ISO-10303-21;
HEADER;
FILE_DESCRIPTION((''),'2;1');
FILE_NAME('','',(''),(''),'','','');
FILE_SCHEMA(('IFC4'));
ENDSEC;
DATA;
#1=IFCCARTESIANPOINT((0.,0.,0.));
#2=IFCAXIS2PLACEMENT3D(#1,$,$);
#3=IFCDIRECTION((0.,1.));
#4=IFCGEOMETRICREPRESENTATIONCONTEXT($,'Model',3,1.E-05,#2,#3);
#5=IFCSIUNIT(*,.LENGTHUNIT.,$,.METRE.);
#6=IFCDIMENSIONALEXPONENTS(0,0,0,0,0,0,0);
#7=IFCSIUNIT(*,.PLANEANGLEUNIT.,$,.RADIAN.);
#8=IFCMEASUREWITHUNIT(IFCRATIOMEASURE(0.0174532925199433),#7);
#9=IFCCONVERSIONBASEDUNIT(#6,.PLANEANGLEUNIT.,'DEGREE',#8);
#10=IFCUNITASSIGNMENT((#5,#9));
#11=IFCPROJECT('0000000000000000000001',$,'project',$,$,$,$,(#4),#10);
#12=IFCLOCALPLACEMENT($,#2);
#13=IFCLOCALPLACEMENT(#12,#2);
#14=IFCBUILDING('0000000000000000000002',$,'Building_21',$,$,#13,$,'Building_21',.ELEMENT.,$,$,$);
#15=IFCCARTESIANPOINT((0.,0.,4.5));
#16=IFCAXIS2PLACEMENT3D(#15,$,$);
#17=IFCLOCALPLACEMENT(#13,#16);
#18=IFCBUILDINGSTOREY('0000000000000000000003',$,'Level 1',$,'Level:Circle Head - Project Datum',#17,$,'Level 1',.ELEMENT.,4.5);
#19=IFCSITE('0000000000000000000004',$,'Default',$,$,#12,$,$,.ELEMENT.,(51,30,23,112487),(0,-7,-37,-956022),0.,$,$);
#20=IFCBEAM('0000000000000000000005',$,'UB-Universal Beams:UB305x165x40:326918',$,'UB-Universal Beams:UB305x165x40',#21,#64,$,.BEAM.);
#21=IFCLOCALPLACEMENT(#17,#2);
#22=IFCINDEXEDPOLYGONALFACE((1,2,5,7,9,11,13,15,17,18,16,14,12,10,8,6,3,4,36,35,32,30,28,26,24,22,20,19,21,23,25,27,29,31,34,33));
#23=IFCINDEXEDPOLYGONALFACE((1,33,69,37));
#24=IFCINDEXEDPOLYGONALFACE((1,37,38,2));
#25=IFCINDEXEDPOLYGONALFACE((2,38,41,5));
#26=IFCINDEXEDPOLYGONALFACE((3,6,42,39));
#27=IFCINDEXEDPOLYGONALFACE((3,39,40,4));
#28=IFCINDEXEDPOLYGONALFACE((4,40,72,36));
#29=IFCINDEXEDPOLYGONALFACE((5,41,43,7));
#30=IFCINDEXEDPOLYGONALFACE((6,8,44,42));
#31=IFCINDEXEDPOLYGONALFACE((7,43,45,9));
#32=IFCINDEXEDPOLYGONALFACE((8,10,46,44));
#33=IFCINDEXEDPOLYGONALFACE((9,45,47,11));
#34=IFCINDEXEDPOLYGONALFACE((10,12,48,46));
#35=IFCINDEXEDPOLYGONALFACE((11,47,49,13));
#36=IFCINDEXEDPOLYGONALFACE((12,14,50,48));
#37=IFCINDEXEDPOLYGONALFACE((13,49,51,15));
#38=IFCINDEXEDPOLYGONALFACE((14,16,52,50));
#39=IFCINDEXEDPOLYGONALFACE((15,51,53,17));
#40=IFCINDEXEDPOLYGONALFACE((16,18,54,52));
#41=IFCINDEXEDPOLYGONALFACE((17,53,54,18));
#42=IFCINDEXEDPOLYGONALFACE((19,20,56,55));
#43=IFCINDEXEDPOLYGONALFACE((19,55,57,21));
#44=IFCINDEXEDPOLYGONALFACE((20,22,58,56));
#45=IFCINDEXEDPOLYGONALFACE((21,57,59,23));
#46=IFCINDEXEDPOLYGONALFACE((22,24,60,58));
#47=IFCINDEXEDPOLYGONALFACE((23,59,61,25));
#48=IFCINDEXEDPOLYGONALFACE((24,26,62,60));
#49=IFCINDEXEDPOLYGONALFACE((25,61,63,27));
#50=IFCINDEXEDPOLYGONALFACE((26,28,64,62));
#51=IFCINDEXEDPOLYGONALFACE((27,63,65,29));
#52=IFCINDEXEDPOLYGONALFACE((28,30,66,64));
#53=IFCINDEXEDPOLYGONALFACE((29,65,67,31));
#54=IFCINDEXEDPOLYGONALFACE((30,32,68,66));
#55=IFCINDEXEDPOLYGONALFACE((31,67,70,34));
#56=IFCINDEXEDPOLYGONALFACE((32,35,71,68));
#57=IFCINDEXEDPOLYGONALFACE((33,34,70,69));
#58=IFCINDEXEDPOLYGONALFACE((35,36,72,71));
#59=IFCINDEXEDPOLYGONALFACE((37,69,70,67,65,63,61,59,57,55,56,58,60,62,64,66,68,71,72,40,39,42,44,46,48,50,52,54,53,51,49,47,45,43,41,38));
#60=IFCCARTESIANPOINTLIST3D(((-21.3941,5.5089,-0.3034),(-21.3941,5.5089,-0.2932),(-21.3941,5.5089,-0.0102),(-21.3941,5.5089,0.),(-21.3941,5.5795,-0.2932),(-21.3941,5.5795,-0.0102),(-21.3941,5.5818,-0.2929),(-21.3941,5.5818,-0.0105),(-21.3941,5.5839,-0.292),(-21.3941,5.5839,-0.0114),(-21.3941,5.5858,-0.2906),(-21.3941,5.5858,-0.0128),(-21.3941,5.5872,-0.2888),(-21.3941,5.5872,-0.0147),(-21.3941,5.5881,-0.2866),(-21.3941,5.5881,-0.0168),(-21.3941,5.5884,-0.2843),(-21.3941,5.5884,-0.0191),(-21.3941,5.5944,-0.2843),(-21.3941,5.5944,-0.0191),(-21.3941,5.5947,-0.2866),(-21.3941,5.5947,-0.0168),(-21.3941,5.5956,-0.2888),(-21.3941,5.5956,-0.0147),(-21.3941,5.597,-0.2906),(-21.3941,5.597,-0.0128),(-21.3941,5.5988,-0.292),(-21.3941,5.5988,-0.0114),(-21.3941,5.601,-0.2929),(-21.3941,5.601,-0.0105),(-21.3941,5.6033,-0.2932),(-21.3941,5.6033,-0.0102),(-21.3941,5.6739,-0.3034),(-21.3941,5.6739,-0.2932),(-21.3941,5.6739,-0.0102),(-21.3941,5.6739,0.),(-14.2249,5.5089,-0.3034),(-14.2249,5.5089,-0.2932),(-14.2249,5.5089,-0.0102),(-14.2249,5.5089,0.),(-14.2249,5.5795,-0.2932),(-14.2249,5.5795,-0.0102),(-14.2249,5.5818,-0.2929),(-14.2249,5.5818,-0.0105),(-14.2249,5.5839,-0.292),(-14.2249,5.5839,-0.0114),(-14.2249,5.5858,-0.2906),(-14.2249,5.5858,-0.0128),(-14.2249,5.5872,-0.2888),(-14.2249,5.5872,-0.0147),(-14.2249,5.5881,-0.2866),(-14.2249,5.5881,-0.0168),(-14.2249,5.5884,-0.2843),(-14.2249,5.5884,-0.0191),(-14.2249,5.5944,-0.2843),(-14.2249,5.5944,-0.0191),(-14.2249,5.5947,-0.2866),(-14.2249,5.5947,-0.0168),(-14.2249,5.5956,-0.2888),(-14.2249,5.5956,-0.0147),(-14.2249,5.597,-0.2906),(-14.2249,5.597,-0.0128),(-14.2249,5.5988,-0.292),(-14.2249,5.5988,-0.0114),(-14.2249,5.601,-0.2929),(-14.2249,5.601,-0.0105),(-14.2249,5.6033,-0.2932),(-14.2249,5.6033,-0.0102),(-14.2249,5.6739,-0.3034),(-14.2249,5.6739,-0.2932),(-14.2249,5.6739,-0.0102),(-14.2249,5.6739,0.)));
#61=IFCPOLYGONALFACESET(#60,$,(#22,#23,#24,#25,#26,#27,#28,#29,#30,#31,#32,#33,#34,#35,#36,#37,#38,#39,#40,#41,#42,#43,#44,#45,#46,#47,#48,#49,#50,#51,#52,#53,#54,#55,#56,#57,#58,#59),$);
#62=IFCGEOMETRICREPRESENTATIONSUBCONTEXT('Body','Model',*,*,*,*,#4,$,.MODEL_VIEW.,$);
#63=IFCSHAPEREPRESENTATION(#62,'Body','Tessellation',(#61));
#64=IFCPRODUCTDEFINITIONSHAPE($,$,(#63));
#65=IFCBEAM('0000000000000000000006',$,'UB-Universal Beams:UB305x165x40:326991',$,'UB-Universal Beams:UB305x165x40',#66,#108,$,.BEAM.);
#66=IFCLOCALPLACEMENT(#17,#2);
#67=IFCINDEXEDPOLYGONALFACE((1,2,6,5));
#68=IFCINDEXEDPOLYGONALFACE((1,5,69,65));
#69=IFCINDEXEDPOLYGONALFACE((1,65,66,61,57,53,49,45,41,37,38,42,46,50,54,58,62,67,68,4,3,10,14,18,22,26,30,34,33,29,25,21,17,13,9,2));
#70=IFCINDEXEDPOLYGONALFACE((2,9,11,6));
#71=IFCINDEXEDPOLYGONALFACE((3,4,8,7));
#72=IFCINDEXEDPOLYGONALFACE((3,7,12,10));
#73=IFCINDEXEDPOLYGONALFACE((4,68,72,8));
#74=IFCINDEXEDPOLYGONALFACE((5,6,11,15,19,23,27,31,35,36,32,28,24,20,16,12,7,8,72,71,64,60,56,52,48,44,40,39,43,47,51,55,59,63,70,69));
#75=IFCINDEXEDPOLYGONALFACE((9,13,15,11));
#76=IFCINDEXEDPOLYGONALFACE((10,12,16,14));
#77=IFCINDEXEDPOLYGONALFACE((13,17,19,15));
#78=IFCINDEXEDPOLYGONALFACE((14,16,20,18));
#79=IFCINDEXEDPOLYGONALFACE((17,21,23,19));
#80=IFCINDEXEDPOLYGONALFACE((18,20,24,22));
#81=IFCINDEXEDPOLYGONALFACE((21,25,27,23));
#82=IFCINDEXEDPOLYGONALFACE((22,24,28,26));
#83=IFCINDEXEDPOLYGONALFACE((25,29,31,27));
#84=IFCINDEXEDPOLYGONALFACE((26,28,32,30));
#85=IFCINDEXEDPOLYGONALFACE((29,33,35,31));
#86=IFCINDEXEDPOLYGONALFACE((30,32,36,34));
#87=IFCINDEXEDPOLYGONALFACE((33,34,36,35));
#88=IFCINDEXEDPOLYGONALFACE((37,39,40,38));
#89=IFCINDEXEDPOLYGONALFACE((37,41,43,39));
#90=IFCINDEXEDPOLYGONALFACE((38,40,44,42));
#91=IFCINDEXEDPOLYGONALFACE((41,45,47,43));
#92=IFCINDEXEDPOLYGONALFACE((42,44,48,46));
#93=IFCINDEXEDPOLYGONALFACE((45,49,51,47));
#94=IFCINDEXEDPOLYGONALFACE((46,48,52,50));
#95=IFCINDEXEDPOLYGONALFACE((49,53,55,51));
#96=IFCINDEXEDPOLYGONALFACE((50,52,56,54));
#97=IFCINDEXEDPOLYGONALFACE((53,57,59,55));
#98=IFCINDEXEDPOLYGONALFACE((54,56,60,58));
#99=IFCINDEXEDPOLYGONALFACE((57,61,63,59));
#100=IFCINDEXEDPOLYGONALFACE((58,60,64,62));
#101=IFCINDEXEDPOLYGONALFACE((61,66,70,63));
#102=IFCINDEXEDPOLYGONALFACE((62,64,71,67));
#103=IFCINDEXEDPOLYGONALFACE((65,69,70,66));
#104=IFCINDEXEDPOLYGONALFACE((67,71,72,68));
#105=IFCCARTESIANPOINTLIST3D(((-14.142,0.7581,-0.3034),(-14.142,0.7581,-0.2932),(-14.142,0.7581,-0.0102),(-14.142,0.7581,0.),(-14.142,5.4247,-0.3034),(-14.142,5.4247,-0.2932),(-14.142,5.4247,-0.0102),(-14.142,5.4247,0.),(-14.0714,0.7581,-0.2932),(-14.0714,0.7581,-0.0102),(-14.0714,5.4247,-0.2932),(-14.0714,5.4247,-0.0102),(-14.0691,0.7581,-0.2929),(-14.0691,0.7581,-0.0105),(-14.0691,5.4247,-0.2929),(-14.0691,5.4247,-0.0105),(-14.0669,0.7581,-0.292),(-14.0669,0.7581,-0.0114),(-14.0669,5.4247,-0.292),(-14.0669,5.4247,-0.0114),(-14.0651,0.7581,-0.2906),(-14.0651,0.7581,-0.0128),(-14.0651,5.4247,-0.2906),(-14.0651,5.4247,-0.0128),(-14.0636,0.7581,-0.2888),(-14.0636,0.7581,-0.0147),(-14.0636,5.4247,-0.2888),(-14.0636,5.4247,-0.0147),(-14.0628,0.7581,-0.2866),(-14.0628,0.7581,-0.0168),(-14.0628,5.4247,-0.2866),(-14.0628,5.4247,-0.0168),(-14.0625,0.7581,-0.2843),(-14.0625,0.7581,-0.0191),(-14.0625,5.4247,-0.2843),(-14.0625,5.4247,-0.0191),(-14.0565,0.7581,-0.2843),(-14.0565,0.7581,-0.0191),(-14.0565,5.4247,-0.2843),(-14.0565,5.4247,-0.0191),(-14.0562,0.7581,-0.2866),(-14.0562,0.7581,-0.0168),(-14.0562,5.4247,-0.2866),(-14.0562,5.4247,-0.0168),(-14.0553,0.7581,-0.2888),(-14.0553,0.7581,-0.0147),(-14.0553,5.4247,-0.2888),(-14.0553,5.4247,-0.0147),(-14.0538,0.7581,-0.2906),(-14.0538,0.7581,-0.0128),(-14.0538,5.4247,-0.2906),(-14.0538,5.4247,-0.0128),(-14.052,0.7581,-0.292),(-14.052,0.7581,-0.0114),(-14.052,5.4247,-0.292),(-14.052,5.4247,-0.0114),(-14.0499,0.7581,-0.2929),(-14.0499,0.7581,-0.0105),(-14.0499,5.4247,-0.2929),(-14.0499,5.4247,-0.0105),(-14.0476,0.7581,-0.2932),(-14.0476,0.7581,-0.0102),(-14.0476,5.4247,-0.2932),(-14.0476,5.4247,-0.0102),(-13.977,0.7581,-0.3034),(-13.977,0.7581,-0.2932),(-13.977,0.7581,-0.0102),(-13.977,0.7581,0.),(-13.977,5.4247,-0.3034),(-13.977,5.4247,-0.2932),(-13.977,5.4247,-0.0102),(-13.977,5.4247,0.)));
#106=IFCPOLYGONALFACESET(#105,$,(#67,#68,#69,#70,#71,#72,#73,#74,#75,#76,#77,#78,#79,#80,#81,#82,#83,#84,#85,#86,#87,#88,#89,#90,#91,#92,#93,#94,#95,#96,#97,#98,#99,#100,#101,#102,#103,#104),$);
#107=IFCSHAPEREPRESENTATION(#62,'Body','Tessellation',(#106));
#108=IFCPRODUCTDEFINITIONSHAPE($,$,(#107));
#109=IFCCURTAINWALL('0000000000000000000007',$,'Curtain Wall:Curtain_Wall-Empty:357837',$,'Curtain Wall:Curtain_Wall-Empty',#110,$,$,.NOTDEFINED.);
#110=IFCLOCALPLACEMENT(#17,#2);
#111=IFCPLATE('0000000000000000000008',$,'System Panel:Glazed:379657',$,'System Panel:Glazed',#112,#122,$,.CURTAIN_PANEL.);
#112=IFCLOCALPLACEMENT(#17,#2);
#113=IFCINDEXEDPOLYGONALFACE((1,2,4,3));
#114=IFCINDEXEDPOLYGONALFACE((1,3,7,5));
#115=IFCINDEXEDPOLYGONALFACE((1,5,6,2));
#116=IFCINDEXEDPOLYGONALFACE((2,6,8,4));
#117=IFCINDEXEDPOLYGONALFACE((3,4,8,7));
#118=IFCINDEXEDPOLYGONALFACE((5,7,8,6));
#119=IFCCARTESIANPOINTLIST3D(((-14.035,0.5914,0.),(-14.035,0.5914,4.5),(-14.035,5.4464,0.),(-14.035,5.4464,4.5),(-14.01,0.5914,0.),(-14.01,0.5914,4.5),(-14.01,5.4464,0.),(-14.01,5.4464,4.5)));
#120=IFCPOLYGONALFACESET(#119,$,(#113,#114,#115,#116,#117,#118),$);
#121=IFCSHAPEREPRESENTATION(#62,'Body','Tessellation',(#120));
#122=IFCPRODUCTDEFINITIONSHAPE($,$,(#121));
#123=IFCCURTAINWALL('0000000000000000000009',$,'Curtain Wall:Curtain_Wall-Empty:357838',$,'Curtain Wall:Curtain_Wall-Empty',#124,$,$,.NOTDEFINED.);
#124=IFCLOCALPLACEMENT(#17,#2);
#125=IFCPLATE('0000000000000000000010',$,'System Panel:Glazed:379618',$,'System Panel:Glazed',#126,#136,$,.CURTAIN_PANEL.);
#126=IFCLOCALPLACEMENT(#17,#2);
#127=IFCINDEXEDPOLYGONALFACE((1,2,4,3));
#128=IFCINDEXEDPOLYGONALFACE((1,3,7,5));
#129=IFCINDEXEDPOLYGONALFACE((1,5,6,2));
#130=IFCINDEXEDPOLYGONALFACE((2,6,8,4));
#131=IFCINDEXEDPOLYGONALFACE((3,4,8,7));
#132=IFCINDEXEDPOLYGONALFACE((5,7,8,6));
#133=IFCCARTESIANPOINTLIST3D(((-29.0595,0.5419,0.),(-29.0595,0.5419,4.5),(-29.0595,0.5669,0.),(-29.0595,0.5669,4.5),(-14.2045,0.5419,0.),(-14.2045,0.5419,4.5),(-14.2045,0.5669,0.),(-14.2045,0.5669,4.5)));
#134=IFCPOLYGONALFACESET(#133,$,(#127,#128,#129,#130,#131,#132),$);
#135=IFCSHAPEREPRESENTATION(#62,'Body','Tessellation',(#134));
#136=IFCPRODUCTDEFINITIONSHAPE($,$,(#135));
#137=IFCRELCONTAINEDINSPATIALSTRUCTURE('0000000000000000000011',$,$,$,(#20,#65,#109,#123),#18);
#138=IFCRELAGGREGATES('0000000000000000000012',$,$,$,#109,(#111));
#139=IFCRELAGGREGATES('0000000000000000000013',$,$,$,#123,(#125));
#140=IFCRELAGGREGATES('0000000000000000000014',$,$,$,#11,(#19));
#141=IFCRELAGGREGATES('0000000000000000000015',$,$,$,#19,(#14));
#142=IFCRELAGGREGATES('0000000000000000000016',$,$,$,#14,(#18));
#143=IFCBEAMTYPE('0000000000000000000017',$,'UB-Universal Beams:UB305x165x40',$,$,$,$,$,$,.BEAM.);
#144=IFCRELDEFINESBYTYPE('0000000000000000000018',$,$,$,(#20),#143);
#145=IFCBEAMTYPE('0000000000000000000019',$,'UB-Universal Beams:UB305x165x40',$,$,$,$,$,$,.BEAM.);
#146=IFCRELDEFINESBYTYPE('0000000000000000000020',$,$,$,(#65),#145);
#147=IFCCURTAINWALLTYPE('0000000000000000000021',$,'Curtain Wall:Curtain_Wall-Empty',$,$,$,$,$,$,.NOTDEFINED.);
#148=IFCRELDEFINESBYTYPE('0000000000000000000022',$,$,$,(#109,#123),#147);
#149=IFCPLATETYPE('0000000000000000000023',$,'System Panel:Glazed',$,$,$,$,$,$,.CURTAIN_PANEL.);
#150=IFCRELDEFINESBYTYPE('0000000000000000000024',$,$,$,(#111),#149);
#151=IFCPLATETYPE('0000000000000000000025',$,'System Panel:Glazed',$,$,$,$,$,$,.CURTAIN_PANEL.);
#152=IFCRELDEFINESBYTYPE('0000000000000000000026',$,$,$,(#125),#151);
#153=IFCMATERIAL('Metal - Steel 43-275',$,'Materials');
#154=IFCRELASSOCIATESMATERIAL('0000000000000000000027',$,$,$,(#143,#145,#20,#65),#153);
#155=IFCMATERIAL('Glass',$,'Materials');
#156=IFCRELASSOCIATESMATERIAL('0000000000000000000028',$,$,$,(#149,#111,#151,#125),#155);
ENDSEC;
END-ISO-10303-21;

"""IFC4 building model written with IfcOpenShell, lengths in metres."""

from ifc_helpers import new_model, entity, si_unit, converted_unit, direction, frame, frame_2d, origin, origin_2d_with_axis, place, context, subcontext, project, spatial, polyline, circle_curve, parameter, trimmed, segment, composite_curve, rectangle, i_section, outline, extrude, source, transform, mapped, material, material_profile, profile_set, profile_usage, type_object, type_shapes, element, aggregate, save


model = new_model("IFC4")

# Units and contexts
model_context = context("Model", 3, precision=1e-05, world=origin(), true_north=direction((0.0, 1.0)))
body_context = subcontext(model_context, "Body", "Model", "MODEL_VIEW")
ifc_project = project(units=[si_unit("LENGTHUNIT", "METRE"), converted_unit("PLANEANGLEUNIT", "DEGREE", entity("IfcRatioMeasure", 0.0174532925199433), si_unit("PLANEANGLEUNIT", "RADIAN"), dimensions=[0, 0, 0, 0, 0, 0, 0])], contexts=[model_context])

# Site, building, storey
site_placement = place(None, origin())
site = spatial("IfcSite", under=ifc_project, at=site_placement, Name="Default", CompositionType="ELEMENT", RefLatitude=(51, 30, 23, 112487), RefLongitude=(0, -7, -37, -956022), RefElevation=0.0)
building_placement = place(site_placement, origin())
building = spatial("IfcBuilding", under=site, at=building_placement, Name="Building_21", LongName="Building_21", CompositionType="ELEMENT")
storey_placement = place(building_placement, frame((0.0, 0.0, 4.5)))
storey = spatial("IfcBuildingStorey", under=building, at=storey_placement, Name="Level 1", ObjectType="Level:Circle Head - Project Datum", LongName="Level 1", CompositionType="ELEMENT", Elevation=4.5)

# Shared definitions
ifc_material_1 = material(Name="Metal - Steel 43-275", Category="Materials")

# Beams
ifc_material_profile_1 = material_profile(ifc_material_1, outline(composite_curve([segment(polyline([(0.0119, -0.1415, 0.0), (0.0825, -0.1415, 0.0)]), True, "CONTINUOUS"), segment(polyline([(0.0825, -0.1415, 0.0), (0.0825, -0.1517, 0.0)]), True, "CONTINUOUS"), segment(polyline([(0.0825, -0.1517, 0.0), (-0.0825, -0.1517, 0.0)]), True, "CONTINUOUS"), segment(polyline([(-0.0825, -0.1517, 0.0), (-0.0825, -0.1415, 0.0)]), True, "CONTINUOUS"), segment(polyline([(-0.0825, -0.1415, 0.0), (-0.0119, -0.1415, 0.0)]), True, "CONTINUOUS"), segment(trimmed(circle_curve(frame((-0.0119, -0.1326, 0.0), z_axis=(0.0, 0.0, 1.0), x_axis=(-1.0, 0.0, 0.0)), 0.0089), [parameter(90.0)], [parameter(180.0)], True, "PARAMETER"), True, "CONTINUOUS"), segment(polyline([(-0.003, -0.1326, 0.0), (-0.003, 0.1326, 0.0)]), True, "CONTINUOUS"), segment(trimmed(circle_curve(frame((-0.0119, 0.1326, 0.0), z_axis=(0.0, 0.0, 1.0), x_axis=(-1.0, 0.0, 0.0)), 0.0089), [parameter(180.0)], [parameter(270.0)], True, "PARAMETER"), True, "CONTINUOUS"), segment(polyline([(-0.0119, 0.1415, 0.0), (-0.0825, 0.1415, 0.0)]), True, "CONTINUOUS"), segment(polyline([(-0.0825, 0.1415, 0.0), (-0.0825, 0.1517, 0.0)]), True, "CONTINUOUS"), segment(polyline([(-0.0825, 0.1517, 0.0), (0.0825, 0.1517, 0.0)]), True, "CONTINUOUS"), segment(polyline([(0.0825, 0.1517, 0.0), (0.0825, 0.1415, 0.0)]), True, "CONTINUOUS"), segment(polyline([(0.0825, 0.1415, 0.0), (0.0119, 0.1415, 0.0)]), True, "CONTINUOUS"), segment(trimmed(circle_curve(frame((0.0119, 0.1326, 0.0), z_axis=(0.0, 0.0, 1.0), x_axis=(-1.0, 0.0, 0.0)), 0.0089), [parameter(270.0)], [parameter(0.0)], True, "PARAMETER"), True, "CONTINUOUS"), segment(polyline([(0.003, 0.1326, 0.0), (0.003, -0.1326, 0.0)]), True, "CONTINUOUS"), segment(trimmed(circle_curve(frame((0.0119, -0.1326, 0.0), z_axis=(0.0, 0.0, 1.0), x_axis=(-1.0, 0.0, 0.0)), 0.0089), [parameter(0.0)], [parameter(90.0)], True, "PARAMETER"), True, "CONTINUOUS")], self_intersect=False), kind="CURVE"), Name="UB305x165x40")
ifc_material_profile_2 = material_profile(ifc_material_1, outline(composite_curve([segment(polyline([(-1.3346, 0.0825, -0.1415), (-1.3346, 0.0825, -0.1517)]), True, "CONTINUOUS"), segment(polyline([(-1.3346, 0.0825, -0.1517), (-1.3346, -0.0825, -0.1517)]), True, "CONTINUOUS"), segment(polyline([(-1.3346, -0.0825, -0.1517), (-1.3346, -0.0825, -0.1415)]), True, "CONTINUOUS"), segment(polyline([(-1.3346, -0.0825, -0.1415), (-1.3346, -0.003, -0.1415)]), True, "CONTINUOUS"), segment(polyline([(-1.3346, -0.003, -0.1415), (-1.3346, -0.003, 0.1415)]), True, "CONTINUOUS"), segment(polyline([(-1.3346, -0.003, 0.1415), (-1.3346, -0.0825, 0.1415)]), True, "CONTINUOUS"), segment(polyline([(-1.3346, -0.0825, 0.1415), (-1.3346, -0.0825, 0.1517)]), True, "CONTINUOUS"), segment(polyline([(-1.3346, -0.0825, 0.1517), (-1.3346, 0.0825, 0.1517)]), True, "CONTINUOUS"), segment(polyline([(-1.3346, 0.0825, 0.1517), (-1.3346, 0.0825, 0.1415)]), True, "CONTINUOUS"), segment(polyline([(-1.3346, 0.0825, 0.1415), (-1.3346, 0.003, 0.1415)]), True, "CONTINUOUS"), segment(polyline([(-1.3346, 0.003, 0.1415), (-1.3346, 0.003, -0.1415)]), True, "CONTINUOUS"), segment(polyline([(-1.3346, 0.003, -0.1415), (-1.3346, 0.0825, -0.1415)]), True, "CONTINUOUS")], self_intersect=False), kind="CURVE"), Name="UB305x165x40")
ifc_profile_set_1 = profile_set([ifc_material_profile_1, ifc_material_profile_2], Name="UB305x165x40")
ifc_profile_usage_1 = profile_usage(ifc_profile_set_1, cardinal=8)
beam_type_1 = type_object("IfcBeamType", Name="UB-Universal Beams:UB305x165x40", PredefinedType="BEAM", material=ifc_profile_set_1)
shared_shape_1 = source(origin(), body_context, "Body", "SweptSolid", [
    extrude(i_section(OverallWidth=0.165, OverallDepth=0.3034, WebThickness=0.006, FlangeThickness=0.0102, FilletRadius=0.0089, at=frame_2d((0.0, 0.0), x_axis=(0.0, 1.0))), frame((-3.5846, 0.0, 0.0), z_axis=(1.0, 0.0, 0.0), x_axis=(0.0, 0.0, -1.0)), (0.0, 0.0, 1.0), 7.1692),
])
type_shapes(beam_type_1, [shared_shape_1])
beam_1_placement = place(storey_placement, frame((-17.8095, 5.5914, -0.1517), z_axis=(0.0, 0.0, 1.0), x_axis=(-1.0, 0.0, 0.0)))
element("IfcBeam", 1, at=beam_1_placement, inside=storey, type_object=beam_type_1, material=ifc_profile_usage_1, Name="UB-Universal Beams:UB305x165x40:326918", ObjectType="UB-Universal Beams:UB305x165x40", PredefinedType="BEAM", context=body_context, shape_type="MappedRepresentation", body=[
    mapped(shared_shape_1, transform((0.0, 0.0, 0.0), scale=1.0)),
])
ifc_profile_usage_2 = profile_usage(ifc_profile_set_1, cardinal=8)
beam_type_2 = type_object("IfcBeamType", Name="UB-Universal Beams:UB305x165x40", PredefinedType="BEAM", material=ifc_profile_set_1)
shared_shape_2 = source(origin(), body_context, "Body", "SweptSolid", [
    extrude(i_section(OverallWidth=0.165, OverallDepth=0.3034, WebThickness=0.006, FlangeThickness=0.0102, FilletRadius=0.0089, at=frame_2d((0.0, 0.0), x_axis=(0.0, 1.0))), frame((-2.3333, 0.0, 0.0), z_axis=(1.0, 0.0, 0.0), x_axis=(0.0, 0.0, -1.0)), (0.0, 0.0, 1.0), 4.6666),
])
type_shapes(beam_type_2, [shared_shape_2])
beam_2_placement = place(storey_placement, frame((-14.0595, 3.0914, -0.1517), z_axis=(0.0, 0.0, 1.0), x_axis=(0.0, 1.0, 0.0)))
element("IfcBeam", 2, at=beam_2_placement, inside=storey, type_object=beam_type_2, material=ifc_profile_usage_2, Name="UB-Universal Beams:UB305x165x40:326991", ObjectType="UB-Universal Beams:UB305x165x40", PredefinedType="BEAM", context=body_context, shape_type="MappedRepresentation", body=[
    mapped(shared_shape_2, transform((0.0, 0.0, 0.0), scale=1.0)),
])

# Curtain walls, plates
curtain_wall_type = type_object("IfcCurtainWallType", Name="Curtain Wall:Curtain_Wall-Empty", PredefinedType="NOTDEFINED")
curtain_wall_1_placement = place(storey_placement, frame((0.0, 0.0, -4.5)))
curtain_wall_1 = element("IfcCurtainWall", 3, at=curtain_wall_1_placement, inside=storey, type_object=curtain_wall_type, Name="Curtain Wall:Curtain_Wall-Empty:357837", ObjectType="Curtain Wall:Curtain_Wall-Empty", PredefinedType="NOTDEFINED")
ifc_material_2 = material(Name="Glass", Category="Materials")
plate_type_1 = type_object("IfcPlateType", Name="System Panel:Glazed", PredefinedType="CURTAIN_PANEL", material=ifc_material_2)
shared_shape_3 = source(origin(), body_context, "Body", "SweptSolid", [
    extrude(rectangle(XDim=0.025, YDim=4.855, at=origin_2d_with_axis()), frame((2.4275, 0.0125, 0.0), z_axis=(0.0, 0.0, 1.0), x_axis=(0.0, 1.0, 0.0)), (0.0, 0.0, 1.0), 4.5),
])
type_shapes(plate_type_1, [shared_shape_3])
plate_1_placement = place(curtain_wall_1_placement, frame((-14.035, 5.4464, 4.5), z_axis=(0.0, 0.0, 1.0), x_axis=(0.0, -1.0, 0.0)))
plate_1 = element("IfcPlate", 4, at=plate_1_placement, type_object=plate_type_1, material=ifc_material_2, Name="System Panel:Glazed:379657", ObjectType="System Panel:Glazed", PredefinedType="CURTAIN_PANEL", context=body_context, shape_type="MappedRepresentation", body=[
    mapped(shared_shape_3, transform((0.0, 0.0, 0.0), scale=1.0)),
])
aggregate(curtain_wall_1, [plate_1])
curtain_wall_2_placement = place(storey_placement, frame((0.0, 0.0, -4.5)))
curtain_wall_2 = element("IfcCurtainWall", 5, at=curtain_wall_2_placement, inside=storey, type_object=curtain_wall_type, Name="Curtain Wall:Curtain_Wall-Empty:357838", ObjectType="Curtain Wall:Curtain_Wall-Empty", PredefinedType="NOTDEFINED")
plate_type_2 = type_object("IfcPlateType", Name="System Panel:Glazed", PredefinedType="CURTAIN_PANEL", material=ifc_material_2)
shared_shape_4 = source(origin(), body_context, "Body", "SweptSolid", [
    extrude(rectangle(XDim=0.025, YDim=14.855, at=origin_2d_with_axis()), frame((7.4275, 0.0125, 0.0), z_axis=(0.0, 0.0, 1.0), x_axis=(0.0, 1.0, 0.0)), (0.0, 0.0, 1.0), 4.5),
])
type_shapes(plate_type_2, [shared_shape_4])
plate_2_placement = place(curtain_wall_2_placement, frame((-14.2045, 0.5669, 4.5), z_axis=(0.0, 0.0, 1.0), x_axis=(-1.0, 0.0, 0.0)))
plate_2 = element("IfcPlate", 6, at=plate_2_placement, type_object=plate_type_2, material=ifc_material_2, Name="System Panel:Glazed:379618", ObjectType="System Panel:Glazed", PredefinedType="CURTAIN_PANEL", context=body_context, shape_type="MappedRepresentation", body=[
    mapped(shared_shape_4, transform((0.0, 0.0, 0.0), scale=1.0)),
])
aggregate(curtain_wall_2, [plate_2])

save(model, "model.ifc")
